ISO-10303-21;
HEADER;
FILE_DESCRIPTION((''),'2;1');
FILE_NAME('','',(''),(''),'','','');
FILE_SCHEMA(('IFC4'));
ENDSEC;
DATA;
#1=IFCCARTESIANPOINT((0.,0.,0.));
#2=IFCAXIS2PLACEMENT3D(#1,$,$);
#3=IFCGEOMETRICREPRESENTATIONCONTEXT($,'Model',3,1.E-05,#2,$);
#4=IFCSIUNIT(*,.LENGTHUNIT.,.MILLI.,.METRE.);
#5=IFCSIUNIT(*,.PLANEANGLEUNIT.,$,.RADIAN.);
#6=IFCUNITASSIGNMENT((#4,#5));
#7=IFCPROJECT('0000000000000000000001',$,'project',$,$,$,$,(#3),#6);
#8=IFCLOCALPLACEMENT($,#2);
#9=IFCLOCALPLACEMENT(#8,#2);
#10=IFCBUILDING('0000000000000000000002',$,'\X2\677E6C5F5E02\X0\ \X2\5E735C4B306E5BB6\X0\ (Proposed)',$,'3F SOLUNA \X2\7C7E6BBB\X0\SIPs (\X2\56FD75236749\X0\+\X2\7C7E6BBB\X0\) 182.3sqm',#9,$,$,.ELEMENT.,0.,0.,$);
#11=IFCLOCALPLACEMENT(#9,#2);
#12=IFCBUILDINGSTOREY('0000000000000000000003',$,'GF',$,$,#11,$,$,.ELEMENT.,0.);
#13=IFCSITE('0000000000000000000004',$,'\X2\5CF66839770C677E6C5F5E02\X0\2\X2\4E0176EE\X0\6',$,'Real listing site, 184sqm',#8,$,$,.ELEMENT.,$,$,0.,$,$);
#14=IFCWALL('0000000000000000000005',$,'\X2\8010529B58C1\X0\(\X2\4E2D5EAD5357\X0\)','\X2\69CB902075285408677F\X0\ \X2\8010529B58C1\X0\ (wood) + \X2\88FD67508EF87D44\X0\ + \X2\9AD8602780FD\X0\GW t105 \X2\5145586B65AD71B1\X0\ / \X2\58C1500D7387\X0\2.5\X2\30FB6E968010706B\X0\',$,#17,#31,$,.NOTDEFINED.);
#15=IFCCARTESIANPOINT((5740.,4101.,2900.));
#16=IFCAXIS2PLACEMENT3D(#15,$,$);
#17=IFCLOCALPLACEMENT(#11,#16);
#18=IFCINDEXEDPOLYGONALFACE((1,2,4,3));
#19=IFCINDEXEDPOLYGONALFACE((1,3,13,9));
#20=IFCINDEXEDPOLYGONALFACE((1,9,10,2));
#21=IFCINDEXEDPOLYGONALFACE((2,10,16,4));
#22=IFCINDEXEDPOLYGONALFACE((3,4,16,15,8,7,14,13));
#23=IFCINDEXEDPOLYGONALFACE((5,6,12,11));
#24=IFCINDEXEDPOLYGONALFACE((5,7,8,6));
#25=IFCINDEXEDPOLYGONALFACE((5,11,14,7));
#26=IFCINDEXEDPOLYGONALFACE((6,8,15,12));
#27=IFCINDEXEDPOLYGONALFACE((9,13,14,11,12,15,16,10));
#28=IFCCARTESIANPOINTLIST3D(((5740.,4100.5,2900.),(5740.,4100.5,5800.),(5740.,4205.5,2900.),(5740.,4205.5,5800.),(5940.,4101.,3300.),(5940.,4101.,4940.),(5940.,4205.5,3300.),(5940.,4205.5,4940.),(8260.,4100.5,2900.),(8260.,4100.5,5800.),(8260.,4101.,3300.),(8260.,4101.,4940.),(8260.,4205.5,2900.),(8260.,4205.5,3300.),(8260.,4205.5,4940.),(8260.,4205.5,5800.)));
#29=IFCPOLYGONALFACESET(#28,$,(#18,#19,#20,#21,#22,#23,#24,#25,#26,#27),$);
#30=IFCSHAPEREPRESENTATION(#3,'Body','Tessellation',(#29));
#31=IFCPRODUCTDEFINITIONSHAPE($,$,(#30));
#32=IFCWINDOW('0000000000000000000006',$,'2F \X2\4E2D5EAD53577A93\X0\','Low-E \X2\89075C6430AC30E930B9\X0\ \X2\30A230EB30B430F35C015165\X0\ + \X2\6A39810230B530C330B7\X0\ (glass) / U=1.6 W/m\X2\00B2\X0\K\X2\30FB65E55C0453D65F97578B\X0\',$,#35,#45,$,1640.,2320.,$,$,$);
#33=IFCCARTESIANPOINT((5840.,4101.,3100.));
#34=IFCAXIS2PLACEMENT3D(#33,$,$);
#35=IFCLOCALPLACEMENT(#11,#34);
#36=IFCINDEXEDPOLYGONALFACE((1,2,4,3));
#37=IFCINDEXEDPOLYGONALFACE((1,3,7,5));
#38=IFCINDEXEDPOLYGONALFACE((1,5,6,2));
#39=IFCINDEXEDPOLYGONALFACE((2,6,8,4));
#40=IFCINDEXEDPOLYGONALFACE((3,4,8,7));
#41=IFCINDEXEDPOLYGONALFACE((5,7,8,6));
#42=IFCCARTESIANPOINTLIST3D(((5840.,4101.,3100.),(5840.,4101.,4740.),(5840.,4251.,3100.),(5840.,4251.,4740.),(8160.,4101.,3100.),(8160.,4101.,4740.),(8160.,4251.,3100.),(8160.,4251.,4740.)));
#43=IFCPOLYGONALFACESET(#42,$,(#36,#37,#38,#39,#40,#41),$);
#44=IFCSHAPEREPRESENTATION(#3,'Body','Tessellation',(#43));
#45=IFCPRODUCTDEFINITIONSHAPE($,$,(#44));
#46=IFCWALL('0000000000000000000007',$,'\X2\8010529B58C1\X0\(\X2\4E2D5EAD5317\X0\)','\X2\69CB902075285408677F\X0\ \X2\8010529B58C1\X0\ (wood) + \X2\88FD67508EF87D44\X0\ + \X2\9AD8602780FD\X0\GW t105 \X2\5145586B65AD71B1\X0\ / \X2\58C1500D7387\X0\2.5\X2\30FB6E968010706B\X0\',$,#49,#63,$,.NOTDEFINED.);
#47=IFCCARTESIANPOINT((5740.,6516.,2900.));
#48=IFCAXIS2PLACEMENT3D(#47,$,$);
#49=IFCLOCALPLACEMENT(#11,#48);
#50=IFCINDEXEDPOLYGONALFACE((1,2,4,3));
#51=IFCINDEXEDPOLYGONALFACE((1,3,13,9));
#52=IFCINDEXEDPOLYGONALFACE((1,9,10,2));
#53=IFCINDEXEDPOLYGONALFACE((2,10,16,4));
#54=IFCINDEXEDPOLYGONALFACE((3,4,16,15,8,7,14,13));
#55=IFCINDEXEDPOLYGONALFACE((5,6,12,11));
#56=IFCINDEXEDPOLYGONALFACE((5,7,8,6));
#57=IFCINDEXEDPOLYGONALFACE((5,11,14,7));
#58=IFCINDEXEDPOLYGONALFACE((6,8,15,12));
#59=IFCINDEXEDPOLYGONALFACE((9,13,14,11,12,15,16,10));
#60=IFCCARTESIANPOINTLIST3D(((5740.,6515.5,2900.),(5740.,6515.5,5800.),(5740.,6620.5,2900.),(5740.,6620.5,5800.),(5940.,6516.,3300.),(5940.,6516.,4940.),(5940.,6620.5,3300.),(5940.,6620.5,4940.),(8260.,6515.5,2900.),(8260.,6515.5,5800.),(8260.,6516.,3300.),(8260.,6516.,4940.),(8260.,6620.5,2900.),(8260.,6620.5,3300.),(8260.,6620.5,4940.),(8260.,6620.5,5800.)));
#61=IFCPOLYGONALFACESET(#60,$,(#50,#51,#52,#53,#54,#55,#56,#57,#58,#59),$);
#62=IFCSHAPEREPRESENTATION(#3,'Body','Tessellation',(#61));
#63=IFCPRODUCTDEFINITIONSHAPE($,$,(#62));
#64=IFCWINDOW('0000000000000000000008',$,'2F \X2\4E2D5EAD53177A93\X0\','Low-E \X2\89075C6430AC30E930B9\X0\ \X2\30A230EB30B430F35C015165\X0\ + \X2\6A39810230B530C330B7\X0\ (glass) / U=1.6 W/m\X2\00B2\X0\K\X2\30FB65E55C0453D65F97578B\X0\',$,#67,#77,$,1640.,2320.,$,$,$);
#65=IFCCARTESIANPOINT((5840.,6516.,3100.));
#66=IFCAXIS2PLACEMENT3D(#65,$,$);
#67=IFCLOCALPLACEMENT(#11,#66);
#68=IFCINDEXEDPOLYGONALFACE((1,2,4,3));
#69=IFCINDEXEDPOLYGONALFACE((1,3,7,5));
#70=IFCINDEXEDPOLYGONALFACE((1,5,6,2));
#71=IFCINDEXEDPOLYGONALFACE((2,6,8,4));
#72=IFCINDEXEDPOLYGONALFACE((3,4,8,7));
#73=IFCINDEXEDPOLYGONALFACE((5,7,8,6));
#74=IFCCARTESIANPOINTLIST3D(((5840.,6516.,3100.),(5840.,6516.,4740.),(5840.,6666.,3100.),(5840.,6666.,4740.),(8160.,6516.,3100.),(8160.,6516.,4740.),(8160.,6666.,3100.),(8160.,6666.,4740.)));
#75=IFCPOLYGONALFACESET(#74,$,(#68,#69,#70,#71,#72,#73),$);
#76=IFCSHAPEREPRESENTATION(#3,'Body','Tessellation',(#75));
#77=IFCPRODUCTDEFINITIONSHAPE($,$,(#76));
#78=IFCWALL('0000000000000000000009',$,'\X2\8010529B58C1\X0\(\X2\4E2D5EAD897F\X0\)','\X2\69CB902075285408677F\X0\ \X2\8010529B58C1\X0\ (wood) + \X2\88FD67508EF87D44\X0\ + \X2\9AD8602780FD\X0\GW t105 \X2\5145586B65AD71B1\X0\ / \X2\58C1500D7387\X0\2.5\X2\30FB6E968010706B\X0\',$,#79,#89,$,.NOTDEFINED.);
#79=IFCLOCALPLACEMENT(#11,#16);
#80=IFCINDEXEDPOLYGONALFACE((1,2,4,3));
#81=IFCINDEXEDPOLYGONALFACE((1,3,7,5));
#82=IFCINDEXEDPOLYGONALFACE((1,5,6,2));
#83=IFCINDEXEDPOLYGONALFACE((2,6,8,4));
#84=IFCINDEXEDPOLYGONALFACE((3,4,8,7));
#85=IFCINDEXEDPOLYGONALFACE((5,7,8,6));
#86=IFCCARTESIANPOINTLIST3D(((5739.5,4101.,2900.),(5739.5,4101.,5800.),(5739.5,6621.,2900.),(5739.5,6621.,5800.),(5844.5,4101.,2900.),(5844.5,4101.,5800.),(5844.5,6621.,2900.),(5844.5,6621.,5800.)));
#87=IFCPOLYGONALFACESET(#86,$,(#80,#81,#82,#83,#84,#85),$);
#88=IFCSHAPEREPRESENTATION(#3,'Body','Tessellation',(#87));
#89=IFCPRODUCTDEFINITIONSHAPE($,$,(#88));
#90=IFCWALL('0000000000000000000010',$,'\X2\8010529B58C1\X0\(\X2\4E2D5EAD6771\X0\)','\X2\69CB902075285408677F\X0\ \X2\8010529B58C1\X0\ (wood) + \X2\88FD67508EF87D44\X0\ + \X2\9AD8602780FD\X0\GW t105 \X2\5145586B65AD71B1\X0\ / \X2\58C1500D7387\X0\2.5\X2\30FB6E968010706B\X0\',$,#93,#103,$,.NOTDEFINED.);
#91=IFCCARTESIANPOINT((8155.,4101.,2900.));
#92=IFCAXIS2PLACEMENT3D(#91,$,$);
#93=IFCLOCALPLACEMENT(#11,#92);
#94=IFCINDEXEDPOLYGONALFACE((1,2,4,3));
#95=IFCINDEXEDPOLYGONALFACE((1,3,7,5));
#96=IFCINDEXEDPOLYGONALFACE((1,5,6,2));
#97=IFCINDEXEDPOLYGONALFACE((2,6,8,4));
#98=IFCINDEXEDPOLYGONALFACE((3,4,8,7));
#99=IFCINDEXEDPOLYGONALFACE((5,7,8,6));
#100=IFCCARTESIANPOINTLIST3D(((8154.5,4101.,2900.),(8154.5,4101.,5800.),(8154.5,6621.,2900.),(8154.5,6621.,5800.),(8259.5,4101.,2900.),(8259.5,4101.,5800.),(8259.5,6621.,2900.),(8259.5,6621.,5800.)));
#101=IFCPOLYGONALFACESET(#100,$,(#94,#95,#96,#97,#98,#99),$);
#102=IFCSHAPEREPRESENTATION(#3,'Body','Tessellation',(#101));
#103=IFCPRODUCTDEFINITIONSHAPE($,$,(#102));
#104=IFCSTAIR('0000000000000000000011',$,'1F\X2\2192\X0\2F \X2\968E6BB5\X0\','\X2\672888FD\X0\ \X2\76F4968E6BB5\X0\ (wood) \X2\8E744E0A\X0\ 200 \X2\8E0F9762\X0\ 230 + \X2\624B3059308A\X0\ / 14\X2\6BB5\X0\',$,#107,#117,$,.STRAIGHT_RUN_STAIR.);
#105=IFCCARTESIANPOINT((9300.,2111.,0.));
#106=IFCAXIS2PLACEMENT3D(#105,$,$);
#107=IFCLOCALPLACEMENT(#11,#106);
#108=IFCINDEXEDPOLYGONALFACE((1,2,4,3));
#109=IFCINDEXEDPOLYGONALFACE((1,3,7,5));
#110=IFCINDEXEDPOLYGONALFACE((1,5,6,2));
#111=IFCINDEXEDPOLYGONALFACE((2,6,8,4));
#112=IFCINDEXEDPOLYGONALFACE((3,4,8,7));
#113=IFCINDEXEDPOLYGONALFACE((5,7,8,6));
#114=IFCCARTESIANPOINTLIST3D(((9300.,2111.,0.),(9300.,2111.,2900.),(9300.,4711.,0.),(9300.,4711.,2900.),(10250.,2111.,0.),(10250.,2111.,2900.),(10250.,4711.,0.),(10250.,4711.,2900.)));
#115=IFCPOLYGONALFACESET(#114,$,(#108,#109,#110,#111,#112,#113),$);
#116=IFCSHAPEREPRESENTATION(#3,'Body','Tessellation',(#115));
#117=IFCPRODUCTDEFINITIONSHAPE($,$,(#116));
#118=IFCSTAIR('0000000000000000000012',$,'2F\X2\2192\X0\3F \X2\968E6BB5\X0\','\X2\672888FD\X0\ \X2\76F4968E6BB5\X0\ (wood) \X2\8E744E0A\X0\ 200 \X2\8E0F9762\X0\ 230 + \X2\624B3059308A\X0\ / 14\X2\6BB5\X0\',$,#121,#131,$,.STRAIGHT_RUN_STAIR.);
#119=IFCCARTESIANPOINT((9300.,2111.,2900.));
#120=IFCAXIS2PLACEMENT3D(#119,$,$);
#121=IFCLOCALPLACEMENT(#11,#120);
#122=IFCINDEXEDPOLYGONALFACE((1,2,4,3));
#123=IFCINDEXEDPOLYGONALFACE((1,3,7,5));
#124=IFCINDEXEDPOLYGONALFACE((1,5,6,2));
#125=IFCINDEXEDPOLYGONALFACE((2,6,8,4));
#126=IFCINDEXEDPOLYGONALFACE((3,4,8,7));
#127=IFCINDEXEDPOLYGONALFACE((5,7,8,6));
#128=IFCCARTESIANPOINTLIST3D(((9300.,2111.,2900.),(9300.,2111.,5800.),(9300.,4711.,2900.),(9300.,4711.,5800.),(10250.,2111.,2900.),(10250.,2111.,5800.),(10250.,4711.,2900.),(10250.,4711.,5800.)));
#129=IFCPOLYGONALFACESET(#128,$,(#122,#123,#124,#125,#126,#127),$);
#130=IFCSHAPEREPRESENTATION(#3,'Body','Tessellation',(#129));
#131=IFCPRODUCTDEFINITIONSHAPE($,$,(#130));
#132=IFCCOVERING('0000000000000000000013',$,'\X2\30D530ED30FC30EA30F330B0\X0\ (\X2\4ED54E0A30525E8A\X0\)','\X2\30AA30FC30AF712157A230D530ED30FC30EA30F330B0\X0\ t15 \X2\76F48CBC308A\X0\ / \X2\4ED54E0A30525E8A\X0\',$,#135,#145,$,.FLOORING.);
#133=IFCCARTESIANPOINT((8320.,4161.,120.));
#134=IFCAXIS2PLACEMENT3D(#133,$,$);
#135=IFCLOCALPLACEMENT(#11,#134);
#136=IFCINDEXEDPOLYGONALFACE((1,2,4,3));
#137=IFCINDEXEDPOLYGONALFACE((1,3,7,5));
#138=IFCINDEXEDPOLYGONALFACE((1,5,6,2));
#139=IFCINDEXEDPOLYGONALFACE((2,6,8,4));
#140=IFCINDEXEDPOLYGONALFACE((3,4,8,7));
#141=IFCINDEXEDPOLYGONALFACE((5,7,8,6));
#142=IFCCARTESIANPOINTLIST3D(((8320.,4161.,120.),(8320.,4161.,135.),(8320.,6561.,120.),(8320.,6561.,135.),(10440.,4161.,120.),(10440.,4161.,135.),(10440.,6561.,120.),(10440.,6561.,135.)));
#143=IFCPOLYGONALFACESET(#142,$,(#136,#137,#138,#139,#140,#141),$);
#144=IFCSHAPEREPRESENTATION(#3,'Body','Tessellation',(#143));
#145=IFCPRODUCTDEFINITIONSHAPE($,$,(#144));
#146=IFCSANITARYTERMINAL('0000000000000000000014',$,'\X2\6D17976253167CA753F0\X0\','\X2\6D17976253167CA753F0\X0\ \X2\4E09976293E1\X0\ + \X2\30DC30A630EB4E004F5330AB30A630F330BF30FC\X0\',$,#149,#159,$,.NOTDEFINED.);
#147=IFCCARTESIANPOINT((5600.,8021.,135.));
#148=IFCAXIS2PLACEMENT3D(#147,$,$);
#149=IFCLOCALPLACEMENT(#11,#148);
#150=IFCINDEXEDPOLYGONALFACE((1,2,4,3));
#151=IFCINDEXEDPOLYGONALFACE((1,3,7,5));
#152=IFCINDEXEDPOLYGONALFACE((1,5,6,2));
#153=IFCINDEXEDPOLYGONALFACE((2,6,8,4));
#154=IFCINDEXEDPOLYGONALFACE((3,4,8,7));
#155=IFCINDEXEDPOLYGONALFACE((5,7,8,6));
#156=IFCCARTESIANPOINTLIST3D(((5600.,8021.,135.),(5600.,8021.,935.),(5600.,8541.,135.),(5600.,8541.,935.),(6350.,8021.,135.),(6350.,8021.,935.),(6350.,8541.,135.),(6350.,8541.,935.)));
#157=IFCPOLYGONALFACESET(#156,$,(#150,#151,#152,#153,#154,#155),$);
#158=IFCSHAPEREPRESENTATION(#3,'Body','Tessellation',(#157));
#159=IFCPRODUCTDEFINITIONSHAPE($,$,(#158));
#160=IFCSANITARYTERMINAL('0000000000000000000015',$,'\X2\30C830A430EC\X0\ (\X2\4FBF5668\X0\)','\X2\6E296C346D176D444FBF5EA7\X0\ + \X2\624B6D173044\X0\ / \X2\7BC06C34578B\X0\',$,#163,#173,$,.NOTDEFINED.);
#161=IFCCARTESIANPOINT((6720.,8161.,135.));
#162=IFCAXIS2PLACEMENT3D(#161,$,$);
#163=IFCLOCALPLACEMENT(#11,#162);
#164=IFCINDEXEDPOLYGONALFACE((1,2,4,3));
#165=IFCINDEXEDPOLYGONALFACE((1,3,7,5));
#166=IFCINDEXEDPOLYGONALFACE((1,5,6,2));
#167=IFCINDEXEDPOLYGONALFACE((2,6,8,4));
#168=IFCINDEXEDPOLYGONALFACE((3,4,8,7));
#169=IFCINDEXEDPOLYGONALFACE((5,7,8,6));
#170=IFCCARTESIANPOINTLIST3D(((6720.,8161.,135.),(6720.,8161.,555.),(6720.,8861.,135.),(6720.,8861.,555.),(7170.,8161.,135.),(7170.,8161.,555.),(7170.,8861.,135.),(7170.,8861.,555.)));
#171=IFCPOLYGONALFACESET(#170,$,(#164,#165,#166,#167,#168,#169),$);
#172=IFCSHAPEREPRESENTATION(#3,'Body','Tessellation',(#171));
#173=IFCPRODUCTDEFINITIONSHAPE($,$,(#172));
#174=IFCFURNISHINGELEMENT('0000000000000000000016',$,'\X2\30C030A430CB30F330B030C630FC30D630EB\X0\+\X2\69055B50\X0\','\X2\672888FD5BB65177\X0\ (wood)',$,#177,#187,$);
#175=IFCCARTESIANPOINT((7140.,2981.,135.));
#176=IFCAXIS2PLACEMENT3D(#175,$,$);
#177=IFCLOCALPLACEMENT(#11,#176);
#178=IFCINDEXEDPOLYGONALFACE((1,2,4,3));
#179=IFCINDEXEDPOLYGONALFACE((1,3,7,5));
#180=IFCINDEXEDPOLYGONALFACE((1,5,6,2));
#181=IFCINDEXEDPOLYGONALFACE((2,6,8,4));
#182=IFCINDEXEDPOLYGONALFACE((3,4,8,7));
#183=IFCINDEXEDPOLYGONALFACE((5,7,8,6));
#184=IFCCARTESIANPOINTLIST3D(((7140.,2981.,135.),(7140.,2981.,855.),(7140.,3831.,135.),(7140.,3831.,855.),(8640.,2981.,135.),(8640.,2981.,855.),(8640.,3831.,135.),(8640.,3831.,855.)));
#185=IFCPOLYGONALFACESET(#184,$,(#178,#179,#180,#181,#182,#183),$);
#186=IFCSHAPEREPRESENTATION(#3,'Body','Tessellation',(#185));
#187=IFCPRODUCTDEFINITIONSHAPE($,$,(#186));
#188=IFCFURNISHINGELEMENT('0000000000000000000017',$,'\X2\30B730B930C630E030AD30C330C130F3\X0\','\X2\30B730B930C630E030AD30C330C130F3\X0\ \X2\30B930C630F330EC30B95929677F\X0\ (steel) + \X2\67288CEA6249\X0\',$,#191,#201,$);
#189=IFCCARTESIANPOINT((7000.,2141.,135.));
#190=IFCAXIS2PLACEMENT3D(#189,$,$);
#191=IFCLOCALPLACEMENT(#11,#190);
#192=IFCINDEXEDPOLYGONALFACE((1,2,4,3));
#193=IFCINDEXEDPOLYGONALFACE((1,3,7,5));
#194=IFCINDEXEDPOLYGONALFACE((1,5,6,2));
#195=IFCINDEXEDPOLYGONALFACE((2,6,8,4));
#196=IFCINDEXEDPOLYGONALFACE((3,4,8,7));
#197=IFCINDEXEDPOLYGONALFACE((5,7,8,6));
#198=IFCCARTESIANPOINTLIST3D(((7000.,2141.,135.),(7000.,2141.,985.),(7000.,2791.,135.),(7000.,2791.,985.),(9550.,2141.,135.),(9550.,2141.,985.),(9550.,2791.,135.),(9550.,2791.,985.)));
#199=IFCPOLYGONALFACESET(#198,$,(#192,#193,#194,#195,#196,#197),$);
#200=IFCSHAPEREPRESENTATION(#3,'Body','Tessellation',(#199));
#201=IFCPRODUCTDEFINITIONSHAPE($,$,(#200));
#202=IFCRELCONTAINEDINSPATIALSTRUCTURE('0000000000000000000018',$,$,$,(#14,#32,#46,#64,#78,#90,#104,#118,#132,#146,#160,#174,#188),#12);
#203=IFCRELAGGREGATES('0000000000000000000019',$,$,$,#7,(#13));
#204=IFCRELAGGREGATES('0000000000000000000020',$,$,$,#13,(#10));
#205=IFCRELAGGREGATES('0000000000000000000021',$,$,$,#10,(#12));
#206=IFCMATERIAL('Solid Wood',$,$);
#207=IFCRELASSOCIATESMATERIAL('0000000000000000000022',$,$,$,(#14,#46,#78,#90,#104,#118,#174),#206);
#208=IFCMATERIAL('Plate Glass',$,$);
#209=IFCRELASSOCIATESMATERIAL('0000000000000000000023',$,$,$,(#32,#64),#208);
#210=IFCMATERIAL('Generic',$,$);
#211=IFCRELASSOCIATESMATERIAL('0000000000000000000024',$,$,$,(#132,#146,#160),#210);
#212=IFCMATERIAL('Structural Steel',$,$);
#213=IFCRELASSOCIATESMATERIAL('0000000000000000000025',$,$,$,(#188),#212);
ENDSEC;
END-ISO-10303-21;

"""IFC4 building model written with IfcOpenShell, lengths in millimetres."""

from ifc_helpers import new_model, si_unit, frame, frame_2d, origin, place, context, project, spatial, rectangle, extrude, material, element, fill, save


model = new_model("IFC4")

# Units and contexts
model_context = context("Model", 3, precision=1e-05, world=origin())
ifc_project = project(units=[si_unit("LENGTHUNIT", "METRE", prefix="MILLI"), si_unit("PLANEANGLEUNIT", "RADIAN")], contexts=[model_context])

# Site, building, storey
site_placement = place(None, origin())
site = spatial("IfcSite", under=ifc_project, at=site_placement, Name="島根県松江市2丁目6", ObjectType="Real listing site, 184sqm", CompositionType="ELEMENT", RefElevation=0.0)
building_placement = place(site_placement, origin())
building = spatial("IfcBuilding", under=site, at=building_placement, Name="松江市 平屋の家 (Proposed)", ObjectType="3F SOLUNA 籾殻SIPs (国産杉+籾殻) 182.3sqm", CompositionType="ELEMENT", ElevationOfRefHeight=0.0, ElevationOfTerrain=0.0)
storey_placement = place(building_placement, origin())
storey = spatial("IfcBuildingStorey", under=building, at=storey_placement, Name="GF", CompositionType="ELEMENT", Elevation=0.0)

# Shared definitions
ifc_material_1 = material(Name="Solid Wood")

# Shared definitions
ifc_material_2 = material(Name="Plate Glass")

# Walls, openings, windows
wall_1_placement = place(storey_placement, frame((5740.0, 4101.0, 2900.0)))
wall_1 = element("IfcWall", 1, at=wall_1_placement, inside=storey, material=ifc_material_1, Name="耐力壁(中庭南)", Description="構造用合板 耐力壁 (wood) + 製材軸組 + 高性能GW t105 充填断熱 / 壁倍率2.5・準耐火", PredefinedType="NOTDEFINED", context=model_context, shape_type="SweptSolid", body=[
    extrude(rectangle(XDim=2520.0, YDim=105.0, at=frame_2d((1260.0, 52.0))), frame((5740.0, 4101.0, 2900.0)), (0.0, 0.0, 1.0), 2900.0),
])
opening_1_placement = place(storey_placement, frame((5840.0, 4101.0, 3100.0)))
opening_1 = element("IfcOpeningElement", 2, at=opening_1_placement, cuts=wall_1, PredefinedType="NOTDEFINED", context=model_context, shape_type="SweptSolid", body=[
    extrude(rectangle(XDim=2320.0, YDim=150.0, at=frame_2d((1160.0, 75.0))), frame((5840.0, 4101.0, 3100.0)), (0.0, 0.0, 1.0), 1640.0),
])
window_1_placement = place(storey_placement, frame((5840.0, 4101.0, 3100.0)))
window_1 = element("IfcWindow", 3, at=window_1_placement, inside=storey, material=ifc_material_2, Name="2F 中庭南窓", Description="Low-E 複層ガラス アルゴン封入 + 樹脂サッシ (glass) / U=1.6 W/m²K・日射取得型", OverallHeight=1640.0, OverallWidth=2320.0, context=model_context, shape_type="SweptSolid", body=[
    extrude(rectangle(XDim=2320.0, YDim=150.0, at=frame_2d((1160.0, 75.0))), frame((5840.0, 4101.0, 3100.0)), (0.0, 0.0, 1.0), 1640.0),
])
fill(opening_1, window_1)
wall_2_placement = place(storey_placement, frame((5740.0, 6516.0, 2900.0)))
wall_2 = element("IfcWall", 4, at=wall_2_placement, inside=storey, material=ifc_material_1, Name="耐力壁(中庭北)", Description="構造用合板 耐力壁 (wood) + 製材軸組 + 高性能GW t105 充填断熱 / 壁倍率2.5・準耐火", PredefinedType="NOTDEFINED", context=model_context, shape_type="SweptSolid", body=[
    extrude(rectangle(XDim=2520.0, YDim=105.0, at=frame_2d((1260.0, 52.0))), frame((5740.0, 6516.0, 2900.0)), (0.0, 0.0, 1.0), 2900.0),
])
opening_2_placement = place(storey_placement, frame((5840.0, 6516.0, 3100.0)))
opening_2 = element("IfcOpeningElement", 5, at=opening_2_placement, cuts=wall_2, PredefinedType="NOTDEFINED", context=model_context, shape_type="SweptSolid", body=[
    extrude(rectangle(XDim=2320.0, YDim=150.0, at=frame_2d((1160.0, 75.0))), frame((5840.0, 6516.0, 3100.0)), (0.0, 0.0, 1.0), 1640.0),
])
window_2_placement = place(storey_placement, frame((5840.0, 6516.0, 3100.0)))
window_2 = element("IfcWindow", 6, at=window_2_placement, inside=storey, material=ifc_material_2, Name="2F 中庭北窓", Description="Low-E 複層ガラス アルゴン封入 + 樹脂サッシ (glass) / U=1.6 W/m²K・日射取得型", OverallHeight=1640.0, OverallWidth=2320.0, context=model_context, shape_type="SweptSolid", body=[
    extrude(rectangle(XDim=2320.0, YDim=150.0, at=frame_2d((1160.0, 75.0))), frame((5840.0, 6516.0, 3100.0)), (0.0, 0.0, 1.0), 1640.0),
])
fill(opening_2, window_2)

# Walls
wall_3_placement = place(storey_placement, frame((5740.0, 4101.0, 2900.0)))
element("IfcWall", 7, at=wall_3_placement, inside=storey, material=ifc_material_1, Name="耐力壁(中庭西)", Description="構造用合板 耐力壁 (wood) + 製材軸組 + 高性能GW t105 充填断熱 / 壁倍率2.5・準耐火", PredefinedType="NOTDEFINED", context=model_context, shape_type="SweptSolid", body=[
    extrude(rectangle(XDim=105.0, YDim=2520.0, at=frame_2d((52.0, 1260.0))), frame((5740.0, 4101.0, 2900.0)), (0.0, 0.0, 1.0), 2900.0),
])
wall_4_placement = place(storey_placement, frame((8155.0, 4101.0, 2900.0)))
element("IfcWall", 8, at=wall_4_placement, inside=storey, material=ifc_material_1, Name="耐力壁(中庭東)", Description="構造用合板 耐力壁 (wood) + 製材軸組 + 高性能GW t105 充填断熱 / 壁倍率2.5・準耐火", PredefinedType="NOTDEFINED", context=model_context, shape_type="SweptSolid", body=[
    extrude(rectangle(XDim=105.0, YDim=2520.0, at=frame_2d((52.0, 1260.0))), frame((8155.0, 4101.0, 2900.0)), (0.0, 0.0, 1.0), 2900.0),
])

# Stairs
stair_1_placement = place(storey_placement, frame((9300.0, 2111.0, 0.0)))
element("IfcStair", 9, at=stair_1_placement, inside=storey, material=ifc_material_1, Name="1F→2F 階段", Description="木製 直階段 (wood) 蹴上 200 踏面 230 + 手すり / 14段", PredefinedType="STRAIGHT_RUN_STAIR", context=model_context, shape_type="SweptSolid", body=[
    extrude(rectangle(XDim=950.0, YDim=2600.0, at=frame_2d((475.0, 1300.0))), frame((9300.0, 2111.0, 0.0)), (0.0, 0.0, 1.0), 2900.0),
])
stair_2_placement = place(storey_placement, frame((9300.0, 2111.0, 2900.0)))
element("IfcStair", 10, at=stair_2_placement, inside=storey, material=ifc_material_1, Name="2F→3F 階段", Description="木製 直階段 (wood) 蹴上 200 踏面 230 + 手すり / 14段", PredefinedType="STRAIGHT_RUN_STAIR", context=model_context, shape_type="SweptSolid", body=[
    extrude(rectangle(XDim=950.0, YDim=2600.0, at=frame_2d((475.0, 1300.0))), frame((9300.0, 2111.0, 2900.0)), (0.0, 0.0, 1.0), 2900.0),
])

# Covering
ifc_material_3 = material(Name="Generic")
covering_placement = place(storey_placement, frame((8320.0, 4161.0, 120.0)))
element("IfcCovering", 11, at=covering_placement, inside=storey, material=ifc_material_3, Name="フローリング (仕上げ床)", Description="オーク無垢フローリング t15 直貼り / 仕上げ床", PredefinedType="FLOORING", context=model_context, shape_type="SweptSolid", body=[
    extrude(rectangle(XDim=2120.0, YDim=2400.0, at=frame_2d((1060.0, 1200.0))), frame((8320.0, 4161.0, 120.0)), (0.0, 0.0, 1.0), 15.0),
])

# Sanitary terminals
sanitary_terminal_1_placement = place(storey_placement, frame((5600.0, 8021.0, 135.0)))
element("IfcSanitaryTerminal", 12, at=sanitary_terminal_1_placement, inside=storey, material=ifc_material_3, Name="洗面化粧台", Description="洗面化粧台 三面鏡 + ボウル一体カウンター", PredefinedType="NOTDEFINED", context=model_context, shape_type="SweptSolid", body=[
    extrude(rectangle(XDim=750.0, YDim=520.0, at=frame_2d((375.0, 260.0))), frame((5600.0, 8021.0, 135.0)), (0.0, 0.0, 1.0), 800.0),
])
sanitary_terminal_2_placement = place(storey_placement, frame((6720.0, 8161.0, 135.0)))
element("IfcSanitaryTerminal", 13, at=sanitary_terminal_2_placement, inside=storey, material=ifc_material_3, Name="トイレ (便器)", Description="温水洗浄便座 + 手洗い / 節水型", PredefinedType="NOTDEFINED", context=model_context, shape_type="SweptSolid", body=[
    extrude(rectangle(XDim=450.0, YDim=700.0, at=frame_2d((225.0, 350.0))), frame((6720.0, 8161.0, 135.0)), (0.0, 0.0, 1.0), 420.0),
])

# Furnishing elements
furnishing_1_placement = place(storey_placement, frame((7140.0, 2981.0, 135.0)))
element("IfcFurnishingElement", 14, at=furnishing_1_placement, inside=storey, material=ifc_material_1, Name="ダイニングテーブル+椅子", Description="木製家具 (wood)", context=model_context, shape_type="SweptSolid", body=[
    extrude(rectangle(XDim=1500.0, YDim=850.0, at=frame_2d((750.0, 425.0))), frame((7140.0, 2981.0, 135.0)), (0.0, 0.0, 1.0), 720.0),
])
ifc_material_4 = material(Name="Structural Steel")
furnishing_2_placement = place(storey_placement, frame((7000.0, 2141.0, 135.0)))
element("IfcFurnishingElement", 15, at=furnishing_2_placement, inside=storey, material=ifc_material_4, Name="システムキッチン", Description="システムキッチン ステンレス天板 (steel) + 木質扉", context=model_context, shape_type="SweptSolid", body=[
    extrude(rectangle(XDim=2550.0, YDim=650.0, at=frame_2d((1275.0, 325.0))), frame((7000.0, 2141.0, 135.0)), (0.0, 0.0, 1.0), 850.0),
])

save(model, "model.ifc")
